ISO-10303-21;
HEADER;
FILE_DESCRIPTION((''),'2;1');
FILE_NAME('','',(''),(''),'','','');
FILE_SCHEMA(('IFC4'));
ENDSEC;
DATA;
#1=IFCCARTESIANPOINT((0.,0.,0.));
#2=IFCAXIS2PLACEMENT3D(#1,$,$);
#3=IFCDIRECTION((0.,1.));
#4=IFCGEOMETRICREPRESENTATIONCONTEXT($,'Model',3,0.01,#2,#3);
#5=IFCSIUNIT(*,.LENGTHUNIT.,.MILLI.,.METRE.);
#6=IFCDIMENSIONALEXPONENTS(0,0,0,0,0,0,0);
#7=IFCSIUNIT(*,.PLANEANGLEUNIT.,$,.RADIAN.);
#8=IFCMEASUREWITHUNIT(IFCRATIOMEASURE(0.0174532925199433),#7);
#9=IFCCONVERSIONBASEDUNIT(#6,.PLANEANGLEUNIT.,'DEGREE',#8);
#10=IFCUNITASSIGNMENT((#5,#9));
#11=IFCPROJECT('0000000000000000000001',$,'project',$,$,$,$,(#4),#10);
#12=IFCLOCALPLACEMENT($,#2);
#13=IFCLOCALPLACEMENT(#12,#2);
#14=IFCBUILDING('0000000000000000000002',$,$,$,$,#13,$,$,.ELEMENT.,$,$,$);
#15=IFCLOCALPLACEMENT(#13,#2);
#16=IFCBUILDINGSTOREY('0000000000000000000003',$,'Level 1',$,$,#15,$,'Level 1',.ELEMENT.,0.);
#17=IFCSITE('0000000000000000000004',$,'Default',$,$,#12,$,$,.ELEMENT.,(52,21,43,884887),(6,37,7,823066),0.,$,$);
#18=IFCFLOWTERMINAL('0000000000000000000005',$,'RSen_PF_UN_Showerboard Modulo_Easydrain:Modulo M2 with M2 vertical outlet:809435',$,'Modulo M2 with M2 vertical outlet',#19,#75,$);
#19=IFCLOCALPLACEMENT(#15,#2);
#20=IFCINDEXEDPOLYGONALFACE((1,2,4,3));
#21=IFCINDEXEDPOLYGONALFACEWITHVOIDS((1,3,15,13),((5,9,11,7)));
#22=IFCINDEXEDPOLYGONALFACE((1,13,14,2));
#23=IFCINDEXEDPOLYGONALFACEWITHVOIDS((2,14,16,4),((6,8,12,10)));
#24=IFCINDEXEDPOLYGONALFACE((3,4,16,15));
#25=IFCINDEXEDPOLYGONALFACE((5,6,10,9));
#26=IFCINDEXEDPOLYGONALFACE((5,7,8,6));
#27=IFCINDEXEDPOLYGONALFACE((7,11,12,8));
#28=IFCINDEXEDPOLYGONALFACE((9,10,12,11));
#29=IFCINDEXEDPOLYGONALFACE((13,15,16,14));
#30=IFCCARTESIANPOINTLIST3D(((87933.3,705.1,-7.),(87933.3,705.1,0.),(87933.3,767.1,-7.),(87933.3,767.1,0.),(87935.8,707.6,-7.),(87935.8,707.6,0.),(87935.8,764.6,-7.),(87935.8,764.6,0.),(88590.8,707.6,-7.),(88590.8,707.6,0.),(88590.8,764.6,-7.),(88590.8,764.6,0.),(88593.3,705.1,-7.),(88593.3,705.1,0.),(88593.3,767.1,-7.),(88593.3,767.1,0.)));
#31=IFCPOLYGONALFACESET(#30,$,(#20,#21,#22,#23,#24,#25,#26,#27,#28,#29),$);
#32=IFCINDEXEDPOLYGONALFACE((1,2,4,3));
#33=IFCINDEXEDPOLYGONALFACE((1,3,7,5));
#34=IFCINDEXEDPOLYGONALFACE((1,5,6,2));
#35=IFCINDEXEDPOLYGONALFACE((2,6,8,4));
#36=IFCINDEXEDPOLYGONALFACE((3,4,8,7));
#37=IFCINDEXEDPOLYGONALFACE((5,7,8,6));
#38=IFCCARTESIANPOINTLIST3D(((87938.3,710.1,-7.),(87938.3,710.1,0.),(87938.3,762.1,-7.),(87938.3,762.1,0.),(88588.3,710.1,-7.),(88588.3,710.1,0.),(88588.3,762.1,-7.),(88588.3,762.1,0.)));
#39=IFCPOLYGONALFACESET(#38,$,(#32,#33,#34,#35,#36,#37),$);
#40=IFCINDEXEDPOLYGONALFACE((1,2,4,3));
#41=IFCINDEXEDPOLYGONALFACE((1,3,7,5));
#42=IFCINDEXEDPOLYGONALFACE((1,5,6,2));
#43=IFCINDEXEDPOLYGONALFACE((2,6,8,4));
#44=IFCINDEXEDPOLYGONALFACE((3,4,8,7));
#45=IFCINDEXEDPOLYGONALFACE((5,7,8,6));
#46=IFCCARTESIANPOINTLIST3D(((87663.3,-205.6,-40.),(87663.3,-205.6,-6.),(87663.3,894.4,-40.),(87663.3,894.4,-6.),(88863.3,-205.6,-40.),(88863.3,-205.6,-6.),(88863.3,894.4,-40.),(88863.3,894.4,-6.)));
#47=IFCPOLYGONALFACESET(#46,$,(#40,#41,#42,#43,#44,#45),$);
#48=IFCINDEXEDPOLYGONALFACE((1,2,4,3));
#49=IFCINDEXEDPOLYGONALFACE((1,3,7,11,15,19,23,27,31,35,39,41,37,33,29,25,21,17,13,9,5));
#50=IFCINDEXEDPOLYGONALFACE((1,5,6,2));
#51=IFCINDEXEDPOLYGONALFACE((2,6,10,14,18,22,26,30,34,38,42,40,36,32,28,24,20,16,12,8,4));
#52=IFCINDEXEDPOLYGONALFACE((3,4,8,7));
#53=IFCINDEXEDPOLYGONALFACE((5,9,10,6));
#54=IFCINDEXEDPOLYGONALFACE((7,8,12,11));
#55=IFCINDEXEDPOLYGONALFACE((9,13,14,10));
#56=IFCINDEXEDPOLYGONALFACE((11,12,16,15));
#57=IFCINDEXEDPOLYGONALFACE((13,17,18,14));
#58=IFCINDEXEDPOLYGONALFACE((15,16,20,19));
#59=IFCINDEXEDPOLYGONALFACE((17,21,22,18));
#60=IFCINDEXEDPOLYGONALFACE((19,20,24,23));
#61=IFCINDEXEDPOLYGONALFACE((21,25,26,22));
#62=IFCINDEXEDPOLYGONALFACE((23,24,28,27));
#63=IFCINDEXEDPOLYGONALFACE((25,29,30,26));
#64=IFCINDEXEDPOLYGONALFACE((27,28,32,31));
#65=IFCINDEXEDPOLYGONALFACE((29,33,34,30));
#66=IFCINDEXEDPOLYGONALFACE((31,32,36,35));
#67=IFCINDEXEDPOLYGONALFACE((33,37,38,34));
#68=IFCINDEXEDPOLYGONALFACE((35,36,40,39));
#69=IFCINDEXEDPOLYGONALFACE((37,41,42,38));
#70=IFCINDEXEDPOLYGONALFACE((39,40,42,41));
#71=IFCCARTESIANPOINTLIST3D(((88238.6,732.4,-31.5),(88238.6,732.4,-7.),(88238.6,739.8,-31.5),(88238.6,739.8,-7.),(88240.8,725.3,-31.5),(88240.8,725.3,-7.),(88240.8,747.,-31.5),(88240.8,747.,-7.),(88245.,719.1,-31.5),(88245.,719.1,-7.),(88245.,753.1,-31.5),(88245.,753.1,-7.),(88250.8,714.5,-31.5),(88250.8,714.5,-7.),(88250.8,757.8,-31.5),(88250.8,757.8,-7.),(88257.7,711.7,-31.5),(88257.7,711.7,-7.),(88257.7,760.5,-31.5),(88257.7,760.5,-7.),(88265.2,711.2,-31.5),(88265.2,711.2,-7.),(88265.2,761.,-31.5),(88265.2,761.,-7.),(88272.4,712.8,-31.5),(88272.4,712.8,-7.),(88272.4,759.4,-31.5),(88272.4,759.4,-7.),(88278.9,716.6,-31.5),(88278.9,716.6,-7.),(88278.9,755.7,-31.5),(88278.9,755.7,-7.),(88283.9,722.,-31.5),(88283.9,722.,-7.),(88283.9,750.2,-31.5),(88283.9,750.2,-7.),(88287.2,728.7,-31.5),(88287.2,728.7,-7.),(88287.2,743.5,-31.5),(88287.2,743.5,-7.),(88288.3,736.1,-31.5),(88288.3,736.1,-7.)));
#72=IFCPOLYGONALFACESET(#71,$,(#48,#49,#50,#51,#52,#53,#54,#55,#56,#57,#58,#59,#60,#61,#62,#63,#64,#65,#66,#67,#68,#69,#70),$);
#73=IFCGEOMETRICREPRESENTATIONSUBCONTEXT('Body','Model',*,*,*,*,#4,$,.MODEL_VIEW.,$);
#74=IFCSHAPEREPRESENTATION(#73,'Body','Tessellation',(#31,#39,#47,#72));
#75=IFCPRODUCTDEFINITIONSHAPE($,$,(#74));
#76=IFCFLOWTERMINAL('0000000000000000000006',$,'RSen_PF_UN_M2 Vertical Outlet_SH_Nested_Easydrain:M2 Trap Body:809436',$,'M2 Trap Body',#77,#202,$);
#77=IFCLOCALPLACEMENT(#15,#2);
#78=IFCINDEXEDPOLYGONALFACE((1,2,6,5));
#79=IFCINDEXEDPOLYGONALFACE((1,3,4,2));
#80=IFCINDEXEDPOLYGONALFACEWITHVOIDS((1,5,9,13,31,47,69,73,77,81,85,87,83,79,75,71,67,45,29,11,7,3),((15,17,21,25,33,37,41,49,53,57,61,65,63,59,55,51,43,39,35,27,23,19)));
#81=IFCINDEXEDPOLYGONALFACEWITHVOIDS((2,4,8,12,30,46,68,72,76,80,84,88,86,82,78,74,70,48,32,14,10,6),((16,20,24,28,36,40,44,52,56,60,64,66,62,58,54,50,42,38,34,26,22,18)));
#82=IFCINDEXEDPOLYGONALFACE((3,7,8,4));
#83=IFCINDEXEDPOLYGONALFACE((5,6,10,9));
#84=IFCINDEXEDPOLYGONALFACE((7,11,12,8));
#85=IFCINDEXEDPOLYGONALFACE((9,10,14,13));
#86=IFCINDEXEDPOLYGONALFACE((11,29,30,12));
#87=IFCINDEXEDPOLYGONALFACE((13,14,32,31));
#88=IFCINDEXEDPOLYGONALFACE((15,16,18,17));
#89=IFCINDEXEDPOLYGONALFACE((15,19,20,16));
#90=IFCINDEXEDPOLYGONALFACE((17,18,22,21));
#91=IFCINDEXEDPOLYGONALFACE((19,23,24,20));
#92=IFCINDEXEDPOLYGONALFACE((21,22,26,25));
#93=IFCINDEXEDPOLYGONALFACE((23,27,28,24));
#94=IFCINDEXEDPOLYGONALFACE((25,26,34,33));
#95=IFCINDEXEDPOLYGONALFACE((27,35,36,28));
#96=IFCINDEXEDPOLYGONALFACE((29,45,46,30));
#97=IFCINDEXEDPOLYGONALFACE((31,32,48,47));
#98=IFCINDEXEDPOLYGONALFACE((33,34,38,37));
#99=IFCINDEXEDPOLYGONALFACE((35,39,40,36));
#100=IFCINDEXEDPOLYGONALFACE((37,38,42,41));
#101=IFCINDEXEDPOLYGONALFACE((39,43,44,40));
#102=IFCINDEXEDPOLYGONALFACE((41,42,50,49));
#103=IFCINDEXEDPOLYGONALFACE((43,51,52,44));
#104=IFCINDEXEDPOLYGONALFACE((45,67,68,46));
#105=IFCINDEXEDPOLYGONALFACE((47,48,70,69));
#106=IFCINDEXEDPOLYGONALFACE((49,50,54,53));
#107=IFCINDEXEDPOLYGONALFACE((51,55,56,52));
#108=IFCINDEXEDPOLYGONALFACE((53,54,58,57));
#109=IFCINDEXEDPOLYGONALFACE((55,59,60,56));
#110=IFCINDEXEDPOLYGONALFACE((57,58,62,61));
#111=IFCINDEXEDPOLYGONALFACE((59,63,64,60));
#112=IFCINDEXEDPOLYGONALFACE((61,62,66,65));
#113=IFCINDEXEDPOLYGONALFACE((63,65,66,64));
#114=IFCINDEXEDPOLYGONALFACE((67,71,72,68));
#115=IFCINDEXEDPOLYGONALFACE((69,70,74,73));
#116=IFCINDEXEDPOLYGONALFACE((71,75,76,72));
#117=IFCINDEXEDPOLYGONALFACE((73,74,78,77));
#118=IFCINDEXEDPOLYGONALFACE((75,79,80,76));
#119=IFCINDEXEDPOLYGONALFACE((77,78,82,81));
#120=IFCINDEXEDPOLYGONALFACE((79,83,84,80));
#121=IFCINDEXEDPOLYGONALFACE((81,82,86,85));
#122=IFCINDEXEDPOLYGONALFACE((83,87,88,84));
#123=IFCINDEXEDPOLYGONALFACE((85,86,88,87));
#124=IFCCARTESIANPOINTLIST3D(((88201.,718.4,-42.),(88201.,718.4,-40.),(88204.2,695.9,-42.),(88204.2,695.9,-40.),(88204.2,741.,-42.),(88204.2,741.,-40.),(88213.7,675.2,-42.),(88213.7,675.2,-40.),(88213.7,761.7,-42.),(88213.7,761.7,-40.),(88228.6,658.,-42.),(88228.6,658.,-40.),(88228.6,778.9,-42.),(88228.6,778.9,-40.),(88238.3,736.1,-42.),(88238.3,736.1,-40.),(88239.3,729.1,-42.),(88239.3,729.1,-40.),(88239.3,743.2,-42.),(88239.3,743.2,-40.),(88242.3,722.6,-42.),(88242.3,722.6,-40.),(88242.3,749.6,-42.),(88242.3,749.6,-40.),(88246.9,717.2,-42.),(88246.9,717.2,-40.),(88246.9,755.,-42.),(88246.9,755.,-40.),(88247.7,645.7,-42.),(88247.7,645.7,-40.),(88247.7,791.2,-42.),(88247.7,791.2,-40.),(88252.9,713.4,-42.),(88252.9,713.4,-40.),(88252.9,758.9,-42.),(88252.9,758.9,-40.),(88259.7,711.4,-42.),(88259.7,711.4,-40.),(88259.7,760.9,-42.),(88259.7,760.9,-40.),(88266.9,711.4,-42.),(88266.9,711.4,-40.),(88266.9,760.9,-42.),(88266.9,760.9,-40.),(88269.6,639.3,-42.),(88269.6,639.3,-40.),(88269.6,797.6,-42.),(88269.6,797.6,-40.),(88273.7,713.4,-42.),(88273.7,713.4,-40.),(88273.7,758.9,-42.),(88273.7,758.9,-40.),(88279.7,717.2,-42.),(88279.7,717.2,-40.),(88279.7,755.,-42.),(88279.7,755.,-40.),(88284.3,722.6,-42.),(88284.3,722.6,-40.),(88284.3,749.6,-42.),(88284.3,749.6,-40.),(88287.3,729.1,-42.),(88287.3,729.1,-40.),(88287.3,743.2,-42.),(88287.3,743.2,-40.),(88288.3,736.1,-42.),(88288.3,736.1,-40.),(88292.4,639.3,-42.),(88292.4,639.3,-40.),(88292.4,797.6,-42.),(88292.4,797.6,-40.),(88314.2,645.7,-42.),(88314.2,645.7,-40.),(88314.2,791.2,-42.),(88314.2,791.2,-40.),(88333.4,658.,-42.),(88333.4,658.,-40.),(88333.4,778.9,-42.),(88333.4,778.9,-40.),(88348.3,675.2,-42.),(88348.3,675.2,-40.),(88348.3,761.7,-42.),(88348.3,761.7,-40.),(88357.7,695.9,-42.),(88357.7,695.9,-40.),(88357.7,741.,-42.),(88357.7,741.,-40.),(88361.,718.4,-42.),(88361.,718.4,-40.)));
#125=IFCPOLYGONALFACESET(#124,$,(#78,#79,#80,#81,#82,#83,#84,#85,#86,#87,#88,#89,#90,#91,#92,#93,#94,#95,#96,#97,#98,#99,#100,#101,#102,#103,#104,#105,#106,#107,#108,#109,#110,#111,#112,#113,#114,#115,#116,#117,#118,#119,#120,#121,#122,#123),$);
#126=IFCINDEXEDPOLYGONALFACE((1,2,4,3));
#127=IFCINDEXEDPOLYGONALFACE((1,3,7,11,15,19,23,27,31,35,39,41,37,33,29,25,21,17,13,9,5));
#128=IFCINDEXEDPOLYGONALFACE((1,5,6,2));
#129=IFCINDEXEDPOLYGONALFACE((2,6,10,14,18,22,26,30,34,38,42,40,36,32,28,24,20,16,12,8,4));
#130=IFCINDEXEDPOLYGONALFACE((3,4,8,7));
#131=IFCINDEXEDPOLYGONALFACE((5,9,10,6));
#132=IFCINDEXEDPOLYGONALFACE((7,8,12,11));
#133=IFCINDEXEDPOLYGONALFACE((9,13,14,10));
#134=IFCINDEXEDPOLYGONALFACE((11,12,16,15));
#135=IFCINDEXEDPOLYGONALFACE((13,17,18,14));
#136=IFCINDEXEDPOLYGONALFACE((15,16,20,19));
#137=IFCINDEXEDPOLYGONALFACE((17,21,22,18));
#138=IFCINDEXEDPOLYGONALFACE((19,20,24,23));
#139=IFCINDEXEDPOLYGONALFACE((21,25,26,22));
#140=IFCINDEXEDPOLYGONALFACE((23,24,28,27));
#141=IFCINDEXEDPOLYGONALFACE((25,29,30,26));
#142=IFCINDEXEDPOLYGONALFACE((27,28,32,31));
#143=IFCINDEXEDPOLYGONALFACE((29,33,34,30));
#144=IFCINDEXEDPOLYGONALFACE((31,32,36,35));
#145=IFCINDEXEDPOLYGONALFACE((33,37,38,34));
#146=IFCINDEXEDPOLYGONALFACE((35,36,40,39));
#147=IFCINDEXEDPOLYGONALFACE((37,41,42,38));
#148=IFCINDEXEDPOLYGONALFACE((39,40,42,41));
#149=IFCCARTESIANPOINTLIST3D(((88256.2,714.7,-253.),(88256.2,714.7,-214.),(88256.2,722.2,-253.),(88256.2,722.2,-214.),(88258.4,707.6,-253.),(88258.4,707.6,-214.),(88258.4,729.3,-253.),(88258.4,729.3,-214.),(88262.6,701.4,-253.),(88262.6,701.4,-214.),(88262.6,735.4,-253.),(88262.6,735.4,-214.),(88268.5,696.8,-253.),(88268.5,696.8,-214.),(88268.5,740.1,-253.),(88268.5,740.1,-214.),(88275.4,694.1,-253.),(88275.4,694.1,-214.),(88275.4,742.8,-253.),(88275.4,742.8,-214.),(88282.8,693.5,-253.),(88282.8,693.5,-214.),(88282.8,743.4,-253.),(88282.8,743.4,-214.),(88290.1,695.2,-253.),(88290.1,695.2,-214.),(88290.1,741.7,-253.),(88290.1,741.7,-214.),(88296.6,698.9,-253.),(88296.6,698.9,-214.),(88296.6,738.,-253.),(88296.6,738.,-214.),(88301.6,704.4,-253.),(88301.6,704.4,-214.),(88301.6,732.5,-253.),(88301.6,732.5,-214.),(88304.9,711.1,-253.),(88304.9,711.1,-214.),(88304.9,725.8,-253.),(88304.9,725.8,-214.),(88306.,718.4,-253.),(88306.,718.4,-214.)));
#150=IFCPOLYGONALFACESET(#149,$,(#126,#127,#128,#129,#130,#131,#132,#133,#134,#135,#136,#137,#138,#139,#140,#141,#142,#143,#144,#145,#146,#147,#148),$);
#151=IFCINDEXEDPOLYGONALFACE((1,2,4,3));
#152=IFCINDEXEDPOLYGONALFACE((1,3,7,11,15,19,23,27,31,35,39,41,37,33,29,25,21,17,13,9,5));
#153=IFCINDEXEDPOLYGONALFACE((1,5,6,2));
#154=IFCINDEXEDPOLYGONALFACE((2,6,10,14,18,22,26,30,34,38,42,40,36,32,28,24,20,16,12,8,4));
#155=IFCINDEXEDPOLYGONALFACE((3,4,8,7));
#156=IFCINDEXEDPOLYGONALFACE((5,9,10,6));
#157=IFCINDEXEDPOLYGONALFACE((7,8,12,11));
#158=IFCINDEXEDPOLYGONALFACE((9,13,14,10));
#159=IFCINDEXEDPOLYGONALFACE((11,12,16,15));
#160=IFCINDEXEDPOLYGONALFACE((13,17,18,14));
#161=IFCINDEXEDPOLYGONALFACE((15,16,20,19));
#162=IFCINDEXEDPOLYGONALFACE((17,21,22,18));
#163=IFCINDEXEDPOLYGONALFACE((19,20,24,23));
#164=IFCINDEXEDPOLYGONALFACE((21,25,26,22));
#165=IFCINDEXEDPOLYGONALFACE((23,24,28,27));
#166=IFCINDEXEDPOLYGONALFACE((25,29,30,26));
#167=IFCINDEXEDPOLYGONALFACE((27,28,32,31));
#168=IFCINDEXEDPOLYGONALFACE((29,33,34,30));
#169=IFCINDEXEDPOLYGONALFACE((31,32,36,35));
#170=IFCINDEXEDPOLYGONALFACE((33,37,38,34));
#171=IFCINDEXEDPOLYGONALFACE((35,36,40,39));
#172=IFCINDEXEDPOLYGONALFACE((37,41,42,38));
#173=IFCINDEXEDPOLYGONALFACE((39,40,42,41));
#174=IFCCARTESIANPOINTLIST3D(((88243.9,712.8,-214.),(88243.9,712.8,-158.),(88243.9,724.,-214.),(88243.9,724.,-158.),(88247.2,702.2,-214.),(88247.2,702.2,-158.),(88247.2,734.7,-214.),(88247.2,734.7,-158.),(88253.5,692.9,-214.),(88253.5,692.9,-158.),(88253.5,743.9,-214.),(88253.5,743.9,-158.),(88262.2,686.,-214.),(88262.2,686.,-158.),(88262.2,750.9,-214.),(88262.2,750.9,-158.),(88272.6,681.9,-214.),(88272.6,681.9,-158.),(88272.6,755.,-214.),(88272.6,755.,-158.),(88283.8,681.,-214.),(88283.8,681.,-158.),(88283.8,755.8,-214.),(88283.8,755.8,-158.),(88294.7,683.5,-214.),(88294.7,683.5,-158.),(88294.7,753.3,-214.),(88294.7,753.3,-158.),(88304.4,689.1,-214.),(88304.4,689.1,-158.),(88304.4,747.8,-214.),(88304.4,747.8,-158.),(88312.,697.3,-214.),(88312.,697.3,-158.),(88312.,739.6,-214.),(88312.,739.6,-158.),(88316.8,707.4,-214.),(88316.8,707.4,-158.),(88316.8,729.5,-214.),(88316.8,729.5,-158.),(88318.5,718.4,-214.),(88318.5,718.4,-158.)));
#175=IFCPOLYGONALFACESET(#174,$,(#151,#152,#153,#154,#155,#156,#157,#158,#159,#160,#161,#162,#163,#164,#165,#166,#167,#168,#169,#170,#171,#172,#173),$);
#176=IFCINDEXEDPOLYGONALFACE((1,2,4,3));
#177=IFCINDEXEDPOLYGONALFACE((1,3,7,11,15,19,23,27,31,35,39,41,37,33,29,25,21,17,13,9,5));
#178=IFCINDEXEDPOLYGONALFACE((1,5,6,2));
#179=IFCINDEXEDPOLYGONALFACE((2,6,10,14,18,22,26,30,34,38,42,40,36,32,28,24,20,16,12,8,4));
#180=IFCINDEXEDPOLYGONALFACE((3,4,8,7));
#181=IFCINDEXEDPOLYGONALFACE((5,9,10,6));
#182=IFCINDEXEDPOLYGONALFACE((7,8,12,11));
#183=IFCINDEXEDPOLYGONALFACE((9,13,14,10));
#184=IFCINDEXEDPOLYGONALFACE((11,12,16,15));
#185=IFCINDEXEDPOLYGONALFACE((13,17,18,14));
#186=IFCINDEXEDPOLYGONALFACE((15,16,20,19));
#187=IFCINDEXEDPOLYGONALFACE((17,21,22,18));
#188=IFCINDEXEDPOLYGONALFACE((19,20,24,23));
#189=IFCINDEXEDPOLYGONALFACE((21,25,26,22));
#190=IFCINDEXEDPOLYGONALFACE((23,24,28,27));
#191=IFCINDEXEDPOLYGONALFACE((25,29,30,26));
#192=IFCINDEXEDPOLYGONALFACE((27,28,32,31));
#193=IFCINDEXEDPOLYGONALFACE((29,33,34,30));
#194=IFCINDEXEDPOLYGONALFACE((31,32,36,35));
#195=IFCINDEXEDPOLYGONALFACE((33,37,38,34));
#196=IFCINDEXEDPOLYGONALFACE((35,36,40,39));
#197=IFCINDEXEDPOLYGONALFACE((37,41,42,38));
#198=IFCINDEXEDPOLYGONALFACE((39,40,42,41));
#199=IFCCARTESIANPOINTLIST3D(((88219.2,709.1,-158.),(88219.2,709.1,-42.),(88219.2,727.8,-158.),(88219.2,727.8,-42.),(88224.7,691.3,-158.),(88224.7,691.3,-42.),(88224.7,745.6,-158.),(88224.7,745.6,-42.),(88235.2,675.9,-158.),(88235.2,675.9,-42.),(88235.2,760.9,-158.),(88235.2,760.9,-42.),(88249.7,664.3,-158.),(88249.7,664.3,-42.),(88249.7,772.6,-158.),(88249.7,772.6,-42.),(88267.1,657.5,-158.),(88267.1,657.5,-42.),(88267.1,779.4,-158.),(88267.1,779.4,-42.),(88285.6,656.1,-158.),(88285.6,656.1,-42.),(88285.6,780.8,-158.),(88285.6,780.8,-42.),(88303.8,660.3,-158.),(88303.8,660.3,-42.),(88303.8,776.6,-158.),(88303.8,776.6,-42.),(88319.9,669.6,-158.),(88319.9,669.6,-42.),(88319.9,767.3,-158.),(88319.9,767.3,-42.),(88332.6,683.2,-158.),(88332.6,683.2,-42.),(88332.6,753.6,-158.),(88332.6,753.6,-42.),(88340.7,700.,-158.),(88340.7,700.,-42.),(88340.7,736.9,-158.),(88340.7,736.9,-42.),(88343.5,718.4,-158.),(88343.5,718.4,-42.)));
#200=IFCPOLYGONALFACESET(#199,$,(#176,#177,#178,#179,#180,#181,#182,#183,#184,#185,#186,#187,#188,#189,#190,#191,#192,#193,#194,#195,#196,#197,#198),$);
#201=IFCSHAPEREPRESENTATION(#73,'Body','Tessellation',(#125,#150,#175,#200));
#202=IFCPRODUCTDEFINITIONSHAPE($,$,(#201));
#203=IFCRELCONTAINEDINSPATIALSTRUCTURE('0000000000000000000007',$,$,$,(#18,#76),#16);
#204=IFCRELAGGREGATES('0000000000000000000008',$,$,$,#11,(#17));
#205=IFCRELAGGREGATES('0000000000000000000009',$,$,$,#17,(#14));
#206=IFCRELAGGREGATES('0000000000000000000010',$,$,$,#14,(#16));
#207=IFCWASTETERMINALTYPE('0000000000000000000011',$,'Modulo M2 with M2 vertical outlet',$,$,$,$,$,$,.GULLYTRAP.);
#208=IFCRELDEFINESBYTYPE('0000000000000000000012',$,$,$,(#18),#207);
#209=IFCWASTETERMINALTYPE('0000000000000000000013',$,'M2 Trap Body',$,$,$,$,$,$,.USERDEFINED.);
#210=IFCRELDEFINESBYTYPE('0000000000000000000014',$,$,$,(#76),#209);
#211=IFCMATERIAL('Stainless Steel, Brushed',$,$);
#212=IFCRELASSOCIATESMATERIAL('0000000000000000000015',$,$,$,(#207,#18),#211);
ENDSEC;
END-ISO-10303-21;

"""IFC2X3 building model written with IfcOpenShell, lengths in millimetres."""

from ifc_helpers import new_model, entity, si_unit, converted_unit, direction, frame, frame_2d, origin, origin_2d_with_axis, place, context, subcontext, project, spatial, polyline, circle_curve, parameter, trimmed, segment, composite_curve, rectangle, circle, outline, extrude, source, transform, mapped, material, type_object, type_shapes, element, save


model = new_model("IFC2X3")

# Units and contexts
model_context = context("Model", 3, precision=0.01, world=origin(), true_north=direction((0.0, 1.0)))
body_context = subcontext(model_context, "Body", "Model", "MODEL_VIEW")
ifc_project = project(units=[si_unit("LENGTHUNIT", "METRE", prefix="MILLI"), converted_unit("PLANEANGLEUNIT", "DEGREE", entity("IfcRatioMeasure", 0.0174532925199433), si_unit("PLANEANGLEUNIT", "RADIAN"), dimensions=[0, 0, 0, 0, 0, 0, 0])], contexts=[model_context])

# Site, building, storey
site_placement = place(None, origin())
site = spatial("IfcSite", under=ifc_project, at=site_placement, Name="Default", CompositionType="ELEMENT", RefLatitude=(52, 21, 43, 884887), RefLongitude=(6, 37, 7, 823066), RefElevation=0.0)
building_placement = place(site_placement, origin())
building = spatial("IfcBuilding", under=site, at=building_placement, CompositionType="ELEMENT")
storey_placement = place(building_placement, origin())
storey = spatial("IfcBuildingStorey", under=building, at=storey_placement, Name="Level 1", LongName="Level 1", CompositionType="ELEMENT", Elevation=0.0)

# Flow terminals
ifc_material_1 = material(Name="Stainless Steel, Brushed")
waste_terminal_type_1 = type_object("IfcWasteTerminalType", Name="Modulo M2 with M2 vertical outlet", PredefinedType="GULLYTRAP", material=ifc_material_1)
shared_shape_1 = source(origin(), body_context, "Body", "SweptSolid", [
    extrude(outline(polyline([(-330.0, -31.0), (330.0, -31.0), (330.0, 31.0), (-330.0, 31.0), (-330.0, -31.0)]), holes=[polyline([(-327.5, -28.5), (-327.5, 28.5), (327.5, 28.5), (327.5, -28.5), (-327.5, -28.5)])]), frame((0.0, -21.0, -7.0), z_axis=(0.0, 0.0, 1.0), x_axis=(-1.0, 0.0, 0.0)), (0.0, 0.0, 1.0), 7.0),
    extrude(rectangle(XDim=650.0, YDim=52.0, at=origin_2d_with_axis()), frame((0.0, -21.0, -7.0), z_axis=(0.0, 0.0, 1.0), x_axis=(-1.0, 0.0, 0.0)), (0.0, 0.0, 1.0), 7.0),
    extrude(rectangle(XDim=1200.0, YDim=1100.0, at=origin_2d_with_axis()), frame((0.0, -412.7, -40.0), z_axis=(0.0, 0.0, 1.0), x_axis=(-1.0, 0.0, 0.0)), (0.0, 0.0, 1.0), 34.0),
    extrude(circle(Radius=25.0, at=frame_2d((0.0, 0.0), x_axis=(1.0, 0.0))), frame((0.0, -21.0, -31.5)), (0.0, 0.0, 1.0), 24.5),
])
type_shapes(waste_terminal_type_1, [shared_shape_1])
flow_terminal_1_placement = place(storey_placement, frame((88263.3, 757.1, 0.0)))
element("IfcFlowTerminal", 1, at=flow_terminal_1_placement, inside=storey, type_object=waste_terminal_type_1, material=ifc_material_1, Name="RSen_PF_UN_Showerboard Modulo_Easydrain:Modulo M2 with M2 vertical outlet:809435", ObjectType="Modulo M2 with M2 vertical outlet", context=body_context, shape_type="MappedRepresentation", body=[
    mapped(shared_shape_1, transform((0.0, 0.0, 0.0), scale=1.0)),
])
waste_terminal_type_2 = type_object("IfcWasteTerminalType", Name="M2 Trap Body", PredefinedType="USERDEFINED")
shared_shape_2 = source(origin(), body_context, "Body", "SweptSolid", [
    extrude(outline(composite_curve([segment(trimmed(circle_curve(origin_2d_with_axis(), 80.0), [parameter(0.0)], [parameter(180.0)], True, "PARAMETER"), True, "CONTINUOUS"), segment(trimmed(circle_curve(origin_2d_with_axis(), 80.0), [parameter(180.0)], [parameter(360.0)], True, "PARAMETER"), True, "CONTINUOUS")], self_intersect=False), holes=[composite_curve([segment(trimmed(circle_curve(frame_2d((-17.7, 17.7), x_axis=(1.0, 0.0)), 25.0), [parameter(180.0)], [parameter(360.0)], True, "PARAMETER"), False, "CONTINUOUS"), segment(trimmed(circle_curve(frame_2d((-17.7, 17.7), x_axis=(1.0, 0.0)), 25.0), [parameter(0.0)], [parameter(180.0)], True, "PARAMETER"), False, "CONTINUOUS")], self_intersect=False)]), frame((17.7, -17.7, -2.0)), (0.0, 0.0, 1.0), 2.0),
    extrude(circle(Radius=25.0, at=frame_2d((0.0, 0.0), x_axis=(1.0, 0.0))), frame((17.7, -17.7, -213.0)), (0.0, 0.0, 1.0), 39.0),
    extrude(circle(Radius=37.5, at=frame_2d((0.0, 0.0), x_axis=(1.0, 0.0))), frame((17.7, -17.7, -174.0)), (0.0, 0.0, 1.0), 56.0),
    extrude(circle(Radius=62.5, at=frame_2d((0.0, 0.0), x_axis=(1.0, 0.0))), frame((17.7, -17.7, -118.0)), (0.0, 0.0, 1.0), 116.0),
])
type_shapes(waste_terminal_type_2, [shared_shape_2])
flow_terminal_2_placement = place(storey_placement, frame((88263.3, 736.1, -40.0)))
element("IfcFlowTerminal", 2, at=flow_terminal_2_placement, inside=storey, type_object=waste_terminal_type_2, Name="RSen_PF_UN_M2 Vertical Outlet_SH_Nested_Easydrain:M2 Trap Body:809436", ObjectType="M2 Trap Body", context=body_context, shape_type="MappedRepresentation", body=[
    mapped(shared_shape_2, transform((0.0, 0.0, 0.0), scale=1.0)),
])

save(model, "model.ifc")
